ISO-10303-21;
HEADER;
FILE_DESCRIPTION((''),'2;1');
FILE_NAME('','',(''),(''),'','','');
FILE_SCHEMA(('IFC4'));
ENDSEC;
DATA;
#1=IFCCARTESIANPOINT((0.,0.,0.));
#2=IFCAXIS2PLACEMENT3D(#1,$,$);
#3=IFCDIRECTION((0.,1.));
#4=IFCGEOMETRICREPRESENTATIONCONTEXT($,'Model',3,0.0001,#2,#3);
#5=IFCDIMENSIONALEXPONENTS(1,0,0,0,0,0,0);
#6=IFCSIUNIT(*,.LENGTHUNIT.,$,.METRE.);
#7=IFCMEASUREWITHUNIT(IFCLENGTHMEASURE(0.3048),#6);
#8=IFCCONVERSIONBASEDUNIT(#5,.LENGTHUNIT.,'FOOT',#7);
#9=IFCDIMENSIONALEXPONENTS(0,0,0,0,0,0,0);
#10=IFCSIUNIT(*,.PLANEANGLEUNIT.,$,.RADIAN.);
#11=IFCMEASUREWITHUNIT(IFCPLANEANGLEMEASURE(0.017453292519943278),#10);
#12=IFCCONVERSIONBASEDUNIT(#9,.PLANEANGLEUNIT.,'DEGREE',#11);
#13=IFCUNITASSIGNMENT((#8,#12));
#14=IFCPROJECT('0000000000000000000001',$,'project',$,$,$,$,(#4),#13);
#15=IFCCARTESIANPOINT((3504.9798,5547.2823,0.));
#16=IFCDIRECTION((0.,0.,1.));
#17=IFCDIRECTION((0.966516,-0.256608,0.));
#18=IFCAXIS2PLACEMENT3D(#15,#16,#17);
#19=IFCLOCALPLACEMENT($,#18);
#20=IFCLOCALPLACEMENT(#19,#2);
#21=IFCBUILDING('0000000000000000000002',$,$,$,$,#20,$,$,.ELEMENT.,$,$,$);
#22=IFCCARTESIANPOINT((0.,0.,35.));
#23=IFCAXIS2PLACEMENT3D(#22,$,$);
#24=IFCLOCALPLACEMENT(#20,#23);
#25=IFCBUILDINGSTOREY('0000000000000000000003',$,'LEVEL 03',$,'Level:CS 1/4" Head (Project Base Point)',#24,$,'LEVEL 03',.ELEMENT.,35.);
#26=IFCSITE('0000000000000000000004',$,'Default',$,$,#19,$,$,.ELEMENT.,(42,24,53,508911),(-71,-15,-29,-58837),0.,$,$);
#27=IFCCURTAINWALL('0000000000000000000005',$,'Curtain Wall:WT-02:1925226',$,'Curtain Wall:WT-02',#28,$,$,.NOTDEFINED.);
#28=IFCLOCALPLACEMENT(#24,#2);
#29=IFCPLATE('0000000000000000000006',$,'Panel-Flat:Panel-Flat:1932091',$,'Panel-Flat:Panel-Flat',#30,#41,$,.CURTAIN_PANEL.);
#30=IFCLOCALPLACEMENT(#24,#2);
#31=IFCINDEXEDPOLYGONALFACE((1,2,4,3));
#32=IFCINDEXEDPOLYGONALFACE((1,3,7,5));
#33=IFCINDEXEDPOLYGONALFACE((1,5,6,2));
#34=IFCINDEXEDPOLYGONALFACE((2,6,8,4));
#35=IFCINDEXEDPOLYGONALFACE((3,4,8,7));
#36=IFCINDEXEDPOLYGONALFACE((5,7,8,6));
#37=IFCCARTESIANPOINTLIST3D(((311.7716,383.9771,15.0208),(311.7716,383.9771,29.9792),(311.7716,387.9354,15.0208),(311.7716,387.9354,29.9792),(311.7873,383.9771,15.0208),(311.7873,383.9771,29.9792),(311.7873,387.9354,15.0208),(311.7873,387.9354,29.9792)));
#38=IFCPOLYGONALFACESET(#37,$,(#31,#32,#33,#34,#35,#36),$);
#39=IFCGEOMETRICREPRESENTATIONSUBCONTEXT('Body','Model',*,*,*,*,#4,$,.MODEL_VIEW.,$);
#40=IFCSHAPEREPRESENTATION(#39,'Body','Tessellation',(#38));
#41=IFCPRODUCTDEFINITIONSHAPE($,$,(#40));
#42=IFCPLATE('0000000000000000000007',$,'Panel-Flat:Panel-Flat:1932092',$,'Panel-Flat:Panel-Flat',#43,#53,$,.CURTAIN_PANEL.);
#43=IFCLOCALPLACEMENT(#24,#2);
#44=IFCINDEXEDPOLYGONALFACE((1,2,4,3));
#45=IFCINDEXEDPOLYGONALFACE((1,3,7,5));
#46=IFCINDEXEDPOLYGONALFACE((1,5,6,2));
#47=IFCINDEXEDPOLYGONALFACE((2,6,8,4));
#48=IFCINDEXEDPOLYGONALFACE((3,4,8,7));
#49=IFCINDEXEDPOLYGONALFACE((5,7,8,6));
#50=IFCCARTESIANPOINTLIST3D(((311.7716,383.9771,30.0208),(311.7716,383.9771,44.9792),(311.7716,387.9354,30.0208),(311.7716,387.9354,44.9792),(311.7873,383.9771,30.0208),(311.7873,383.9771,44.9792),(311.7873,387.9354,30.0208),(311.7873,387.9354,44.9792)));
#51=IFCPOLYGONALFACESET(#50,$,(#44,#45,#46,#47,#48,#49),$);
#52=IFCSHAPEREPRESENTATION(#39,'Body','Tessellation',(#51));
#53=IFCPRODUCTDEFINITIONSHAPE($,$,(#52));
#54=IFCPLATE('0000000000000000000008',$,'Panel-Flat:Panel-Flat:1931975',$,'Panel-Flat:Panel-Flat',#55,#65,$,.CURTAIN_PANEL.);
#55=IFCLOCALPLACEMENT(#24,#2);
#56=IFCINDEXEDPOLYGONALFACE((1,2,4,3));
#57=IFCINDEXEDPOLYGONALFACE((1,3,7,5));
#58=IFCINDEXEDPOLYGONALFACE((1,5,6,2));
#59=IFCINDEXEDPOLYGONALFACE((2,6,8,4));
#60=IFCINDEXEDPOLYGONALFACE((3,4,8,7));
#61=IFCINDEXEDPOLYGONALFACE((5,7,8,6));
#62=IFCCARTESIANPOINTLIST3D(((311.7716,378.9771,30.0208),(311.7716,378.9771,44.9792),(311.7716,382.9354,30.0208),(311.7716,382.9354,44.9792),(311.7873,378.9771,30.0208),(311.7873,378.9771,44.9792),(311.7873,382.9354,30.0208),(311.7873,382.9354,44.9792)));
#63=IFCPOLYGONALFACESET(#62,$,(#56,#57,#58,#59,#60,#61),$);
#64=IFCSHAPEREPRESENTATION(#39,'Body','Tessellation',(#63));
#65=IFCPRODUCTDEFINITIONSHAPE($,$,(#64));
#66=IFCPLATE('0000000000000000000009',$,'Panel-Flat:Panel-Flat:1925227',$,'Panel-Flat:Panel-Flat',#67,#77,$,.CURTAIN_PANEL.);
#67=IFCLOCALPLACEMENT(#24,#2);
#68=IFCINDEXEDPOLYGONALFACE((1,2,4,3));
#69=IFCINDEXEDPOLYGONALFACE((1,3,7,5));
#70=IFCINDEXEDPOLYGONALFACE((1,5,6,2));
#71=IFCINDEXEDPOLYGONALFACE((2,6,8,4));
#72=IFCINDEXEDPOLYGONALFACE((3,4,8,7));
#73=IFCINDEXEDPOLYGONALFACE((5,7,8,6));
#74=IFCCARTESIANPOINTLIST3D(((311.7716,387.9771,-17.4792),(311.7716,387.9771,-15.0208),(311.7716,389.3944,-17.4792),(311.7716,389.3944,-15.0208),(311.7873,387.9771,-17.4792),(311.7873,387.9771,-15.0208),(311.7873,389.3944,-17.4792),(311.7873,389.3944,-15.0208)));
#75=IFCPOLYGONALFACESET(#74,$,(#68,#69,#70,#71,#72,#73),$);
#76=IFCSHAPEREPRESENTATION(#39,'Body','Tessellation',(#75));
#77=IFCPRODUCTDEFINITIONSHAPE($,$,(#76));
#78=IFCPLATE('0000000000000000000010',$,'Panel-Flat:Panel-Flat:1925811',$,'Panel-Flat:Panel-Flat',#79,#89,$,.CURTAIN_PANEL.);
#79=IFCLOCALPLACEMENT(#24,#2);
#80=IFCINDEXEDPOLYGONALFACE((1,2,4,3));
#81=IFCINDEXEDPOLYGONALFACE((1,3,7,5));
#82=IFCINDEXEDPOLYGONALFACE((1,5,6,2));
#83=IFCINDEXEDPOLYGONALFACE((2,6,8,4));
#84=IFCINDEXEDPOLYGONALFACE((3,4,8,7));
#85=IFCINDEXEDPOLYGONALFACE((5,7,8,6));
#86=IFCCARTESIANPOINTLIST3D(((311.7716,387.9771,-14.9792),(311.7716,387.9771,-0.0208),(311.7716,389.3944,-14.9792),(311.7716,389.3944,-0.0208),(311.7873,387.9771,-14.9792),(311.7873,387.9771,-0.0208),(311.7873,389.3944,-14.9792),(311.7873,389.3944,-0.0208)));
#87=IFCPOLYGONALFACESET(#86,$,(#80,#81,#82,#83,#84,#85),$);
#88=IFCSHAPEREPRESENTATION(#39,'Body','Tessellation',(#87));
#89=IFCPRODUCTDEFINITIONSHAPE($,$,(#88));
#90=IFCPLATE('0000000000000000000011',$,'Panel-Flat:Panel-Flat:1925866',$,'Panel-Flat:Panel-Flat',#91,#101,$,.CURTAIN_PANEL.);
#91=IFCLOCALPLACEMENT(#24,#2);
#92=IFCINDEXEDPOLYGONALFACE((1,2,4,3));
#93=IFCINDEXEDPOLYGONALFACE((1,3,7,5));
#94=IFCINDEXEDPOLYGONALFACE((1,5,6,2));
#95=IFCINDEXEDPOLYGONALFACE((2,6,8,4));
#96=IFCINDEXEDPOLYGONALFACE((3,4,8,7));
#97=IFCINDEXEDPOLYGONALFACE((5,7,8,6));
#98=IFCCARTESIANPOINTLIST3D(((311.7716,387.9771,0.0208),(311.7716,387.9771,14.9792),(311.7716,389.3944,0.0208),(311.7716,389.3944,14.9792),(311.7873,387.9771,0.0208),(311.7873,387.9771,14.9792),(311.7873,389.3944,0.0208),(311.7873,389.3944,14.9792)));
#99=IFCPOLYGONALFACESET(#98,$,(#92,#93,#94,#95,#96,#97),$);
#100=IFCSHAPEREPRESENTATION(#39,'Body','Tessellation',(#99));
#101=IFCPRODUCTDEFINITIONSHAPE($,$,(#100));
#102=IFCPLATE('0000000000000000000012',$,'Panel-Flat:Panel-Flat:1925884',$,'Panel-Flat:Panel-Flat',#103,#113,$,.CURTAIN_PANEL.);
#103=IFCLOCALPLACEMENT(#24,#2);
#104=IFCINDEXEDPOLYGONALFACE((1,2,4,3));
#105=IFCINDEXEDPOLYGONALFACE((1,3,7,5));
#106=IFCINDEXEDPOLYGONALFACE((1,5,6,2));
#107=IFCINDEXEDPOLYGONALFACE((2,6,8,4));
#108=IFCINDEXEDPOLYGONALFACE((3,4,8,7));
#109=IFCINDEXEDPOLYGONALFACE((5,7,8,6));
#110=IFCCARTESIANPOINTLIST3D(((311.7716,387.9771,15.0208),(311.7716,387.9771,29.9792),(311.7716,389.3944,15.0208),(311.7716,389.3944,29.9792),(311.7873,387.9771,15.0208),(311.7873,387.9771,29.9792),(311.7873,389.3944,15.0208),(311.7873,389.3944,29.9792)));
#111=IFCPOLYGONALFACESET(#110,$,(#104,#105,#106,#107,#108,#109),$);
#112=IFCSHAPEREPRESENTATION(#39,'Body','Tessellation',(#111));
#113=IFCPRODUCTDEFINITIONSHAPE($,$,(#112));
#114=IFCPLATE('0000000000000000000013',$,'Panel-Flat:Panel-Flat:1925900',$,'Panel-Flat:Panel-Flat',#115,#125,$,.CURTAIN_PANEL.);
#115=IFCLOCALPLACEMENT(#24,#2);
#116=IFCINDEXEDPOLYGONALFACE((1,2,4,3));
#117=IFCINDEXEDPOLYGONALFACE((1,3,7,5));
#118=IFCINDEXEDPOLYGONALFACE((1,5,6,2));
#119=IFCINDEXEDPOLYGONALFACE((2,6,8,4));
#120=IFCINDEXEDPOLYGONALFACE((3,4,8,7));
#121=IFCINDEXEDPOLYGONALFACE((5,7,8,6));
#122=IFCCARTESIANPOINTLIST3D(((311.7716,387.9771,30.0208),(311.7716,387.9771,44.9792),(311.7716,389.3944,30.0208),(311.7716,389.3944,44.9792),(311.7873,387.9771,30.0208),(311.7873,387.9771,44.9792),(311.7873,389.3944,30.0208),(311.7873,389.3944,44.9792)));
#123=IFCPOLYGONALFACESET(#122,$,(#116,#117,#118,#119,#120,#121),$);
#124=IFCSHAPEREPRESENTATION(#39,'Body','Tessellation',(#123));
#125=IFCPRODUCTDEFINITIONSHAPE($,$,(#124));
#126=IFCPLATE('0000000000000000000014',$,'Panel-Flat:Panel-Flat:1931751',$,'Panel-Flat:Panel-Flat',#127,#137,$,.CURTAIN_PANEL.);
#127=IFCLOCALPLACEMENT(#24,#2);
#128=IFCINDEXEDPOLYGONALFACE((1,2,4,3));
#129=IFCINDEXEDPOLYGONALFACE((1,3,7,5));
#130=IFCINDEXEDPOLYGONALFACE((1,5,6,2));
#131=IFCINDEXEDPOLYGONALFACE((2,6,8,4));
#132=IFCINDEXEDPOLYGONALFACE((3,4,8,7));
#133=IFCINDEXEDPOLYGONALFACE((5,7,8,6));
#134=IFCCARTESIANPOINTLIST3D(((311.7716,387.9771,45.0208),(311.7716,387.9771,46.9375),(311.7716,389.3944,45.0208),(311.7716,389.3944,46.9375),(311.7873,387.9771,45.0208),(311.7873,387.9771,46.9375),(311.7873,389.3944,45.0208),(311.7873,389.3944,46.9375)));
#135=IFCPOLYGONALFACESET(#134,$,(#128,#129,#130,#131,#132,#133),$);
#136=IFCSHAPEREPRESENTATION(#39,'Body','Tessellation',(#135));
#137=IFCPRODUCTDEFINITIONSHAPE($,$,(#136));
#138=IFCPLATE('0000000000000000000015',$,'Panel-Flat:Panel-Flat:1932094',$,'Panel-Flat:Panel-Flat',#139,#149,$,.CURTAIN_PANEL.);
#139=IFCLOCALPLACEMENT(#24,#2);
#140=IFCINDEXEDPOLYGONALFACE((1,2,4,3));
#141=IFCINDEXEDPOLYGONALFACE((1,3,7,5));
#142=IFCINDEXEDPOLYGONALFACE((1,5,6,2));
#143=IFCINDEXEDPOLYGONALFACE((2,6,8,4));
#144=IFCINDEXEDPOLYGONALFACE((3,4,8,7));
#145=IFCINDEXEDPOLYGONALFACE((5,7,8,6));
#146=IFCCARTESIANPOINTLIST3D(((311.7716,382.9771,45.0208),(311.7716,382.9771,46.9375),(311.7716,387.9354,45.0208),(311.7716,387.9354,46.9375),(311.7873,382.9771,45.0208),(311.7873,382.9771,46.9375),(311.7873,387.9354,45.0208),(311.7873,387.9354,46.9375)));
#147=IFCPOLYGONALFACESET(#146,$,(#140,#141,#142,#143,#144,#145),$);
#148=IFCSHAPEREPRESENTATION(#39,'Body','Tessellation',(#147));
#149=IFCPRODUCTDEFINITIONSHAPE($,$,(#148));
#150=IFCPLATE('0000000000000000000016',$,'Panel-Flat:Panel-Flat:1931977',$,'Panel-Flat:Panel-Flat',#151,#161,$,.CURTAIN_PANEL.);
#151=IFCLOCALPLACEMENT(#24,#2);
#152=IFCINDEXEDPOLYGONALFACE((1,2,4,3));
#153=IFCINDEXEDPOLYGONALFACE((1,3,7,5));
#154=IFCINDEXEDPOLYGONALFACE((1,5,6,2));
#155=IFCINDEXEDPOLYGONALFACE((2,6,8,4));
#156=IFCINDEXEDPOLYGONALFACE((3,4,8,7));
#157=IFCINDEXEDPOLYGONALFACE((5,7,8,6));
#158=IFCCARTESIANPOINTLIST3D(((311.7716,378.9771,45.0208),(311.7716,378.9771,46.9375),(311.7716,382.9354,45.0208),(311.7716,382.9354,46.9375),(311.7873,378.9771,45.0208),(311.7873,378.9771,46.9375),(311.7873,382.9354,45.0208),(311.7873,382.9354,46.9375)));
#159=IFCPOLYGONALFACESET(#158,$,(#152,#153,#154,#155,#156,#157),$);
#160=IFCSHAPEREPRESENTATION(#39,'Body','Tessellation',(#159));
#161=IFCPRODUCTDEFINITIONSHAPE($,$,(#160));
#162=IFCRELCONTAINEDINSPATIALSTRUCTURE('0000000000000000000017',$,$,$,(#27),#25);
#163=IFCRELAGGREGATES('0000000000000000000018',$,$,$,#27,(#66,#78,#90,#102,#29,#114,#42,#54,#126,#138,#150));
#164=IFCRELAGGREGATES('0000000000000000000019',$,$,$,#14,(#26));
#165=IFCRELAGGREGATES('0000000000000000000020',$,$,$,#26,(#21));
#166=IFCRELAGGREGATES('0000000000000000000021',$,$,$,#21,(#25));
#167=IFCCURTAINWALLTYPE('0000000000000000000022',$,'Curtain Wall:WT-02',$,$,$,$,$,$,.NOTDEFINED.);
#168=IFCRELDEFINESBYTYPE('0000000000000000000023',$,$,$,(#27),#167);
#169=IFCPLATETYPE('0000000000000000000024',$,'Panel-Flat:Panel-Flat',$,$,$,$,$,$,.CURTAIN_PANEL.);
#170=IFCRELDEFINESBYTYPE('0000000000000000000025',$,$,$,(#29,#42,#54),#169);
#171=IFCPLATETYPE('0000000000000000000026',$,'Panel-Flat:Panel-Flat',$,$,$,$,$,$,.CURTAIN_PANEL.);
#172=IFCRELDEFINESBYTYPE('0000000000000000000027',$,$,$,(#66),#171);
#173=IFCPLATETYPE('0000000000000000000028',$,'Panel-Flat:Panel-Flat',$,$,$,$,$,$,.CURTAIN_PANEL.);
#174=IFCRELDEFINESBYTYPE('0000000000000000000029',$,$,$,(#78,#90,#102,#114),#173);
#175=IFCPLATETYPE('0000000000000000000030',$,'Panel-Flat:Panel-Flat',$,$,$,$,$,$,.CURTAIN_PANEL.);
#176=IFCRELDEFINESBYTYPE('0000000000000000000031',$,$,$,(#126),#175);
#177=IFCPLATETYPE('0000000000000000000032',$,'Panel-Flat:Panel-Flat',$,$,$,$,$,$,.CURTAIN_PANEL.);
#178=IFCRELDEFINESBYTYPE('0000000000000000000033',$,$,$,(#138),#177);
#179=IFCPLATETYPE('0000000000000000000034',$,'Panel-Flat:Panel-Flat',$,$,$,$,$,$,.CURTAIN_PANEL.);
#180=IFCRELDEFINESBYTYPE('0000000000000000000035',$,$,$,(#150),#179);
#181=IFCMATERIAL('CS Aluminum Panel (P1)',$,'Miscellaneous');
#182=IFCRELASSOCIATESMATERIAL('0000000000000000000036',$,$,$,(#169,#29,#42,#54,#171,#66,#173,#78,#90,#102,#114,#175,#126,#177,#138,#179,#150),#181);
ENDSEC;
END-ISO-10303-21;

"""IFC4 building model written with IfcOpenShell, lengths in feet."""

from ifc_helpers import new_model, entity, si_unit, converted_unit, direction, frame, origin, place, context, subcontext, project, spatial, indexed_curve, outline, extrude, source, transform, mapped, material, type_object, type_shapes, element, aggregate, save


model = new_model("IFC4")

# Units and contexts
model_context = context("Model", 3, precision=0.0001, world=origin(), true_north=direction((0.0, 1.0)))
body_context = subcontext(model_context, "Body", "Model", "MODEL_VIEW")
ifc_project = project(units=[converted_unit("LENGTHUNIT", "FOOT", entity("IfcLengthMeasure", 0.3048), si_unit("LENGTHUNIT", "METRE"), dimensions=[1, 0, 0, 0, 0, 0, 0]), converted_unit("PLANEANGLEUNIT", "DEGREE", entity("IfcPlaneAngleMeasure", 0.017453292519943278), si_unit("PLANEANGLEUNIT", "RADIAN"), dimensions=[0, 0, 0, 0, 0, 0, 0])], contexts=[model_context])

# Site, building, storey
site_placement = place(None, frame((3504.9798, 5547.2823, 0.0), z_axis=(0.0, 0.0, 1.0), x_axis=(0.966516, -0.256608, 0.0)))
site = spatial("IfcSite", under=ifc_project, at=site_placement, Name="Default", CompositionType="ELEMENT", RefLatitude=(42, 24, 53, 508911), RefLongitude=(-71, -15, -29, -58837), RefElevation=0.0)
building_placement = place(site_placement, origin())
building = spatial("IfcBuilding", under=site, at=building_placement, CompositionType="ELEMENT")
storey_placement = place(building_placement, frame((0.0, 0.0, 35.0)))
storey = spatial("IfcBuildingStorey", under=building, at=storey_placement, Name="LEVEL 03", ObjectType="Level:CS 1/4\" Head (Project Base Point)", LongName="LEVEL 03", CompositionType="ELEMENT", Elevation=35.0)

# Curtain wall, plates
curtain_wall_type = type_object("IfcCurtainWallType", Name="Curtain Wall:WT-02", PredefinedType="NOTDEFINED")
curtain_wall_1_placement = place(storey_placement, frame((0.0, 0.0, -35.0)))
curtain_wall_1 = element("IfcCurtainWall", 1, at=curtain_wall_1_placement, inside=storey, type_object=curtain_wall_type, Name="Curtain Wall:WT-02:1925226", ObjectType="Curtain Wall:WT-02", PredefinedType="NOTDEFINED")
ifc_material_1 = material(Name="CS Aluminum Panel (P1)", Category="Miscellaneous")
plate_type_1 = type_object("IfcPlateType", Name="Panel-Flat:Panel-Flat", PredefinedType="CURTAIN_PANEL", material=ifc_material_1)
shared_shape_1 = source(origin(), body_context, "Body", "SweptSolid", [
    extrude(outline(indexed_curve([(-0.0078, -1.9792), (0.0078, -1.9792), (0.0078, 1.9792), (-0.0078, 1.9792), (-0.0078, -1.9792)], self_intersect=False)), frame((1.9792, 0.0078, 0.0), z_axis=(0.0, 0.0, 1.0), x_axis=(0.0, -1.0, 0.0)), (0.0, 0.0, 1.0), 14.9583),
])
type_shapes(plate_type_1, [shared_shape_1])
plate_1_placement = place(curtain_wall_1_placement, frame((311.7716, 387.9354, 50.0208), z_axis=(0.0, 0.0, 1.0), x_axis=(0.0, -1.0, 0.0)))
plate_1 = element("IfcPlate", 2, at=plate_1_placement, type_object=plate_type_1, material=ifc_material_1, Name="Panel-Flat:Panel-Flat:1932091", ObjectType="Panel-Flat:Panel-Flat", PredefinedType="CURTAIN_PANEL", context=body_context, shape_type="MappedRepresentation", body=[
    mapped(shared_shape_1, transform((0.0, 0.0, 0.0), scale=1.0)),
])
plate_2_placement = place(curtain_wall_1_placement, frame((311.7716, 387.9354, 65.0208), z_axis=(0.0, 0.0, 1.0), x_axis=(0.0, -1.0, 0.0)))
plate_2 = element("IfcPlate", 3, at=plate_2_placement, type_object=plate_type_1, material=ifc_material_1, Name="Panel-Flat:Panel-Flat:1932092", ObjectType="Panel-Flat:Panel-Flat", PredefinedType="CURTAIN_PANEL", context=body_context, shape_type="MappedRepresentation", body=[
    mapped(shared_shape_1, transform((0.0, 0.0, 0.0), scale=1.0)),
])
plate_3_placement = place(curtain_wall_1_placement, frame((311.7716, 382.9354, 65.0208), z_axis=(0.0, 0.0, 1.0), x_axis=(0.0, -1.0, 0.0)))
plate_3 = element("IfcPlate", 4, at=plate_3_placement, type_object=plate_type_1, material=ifc_material_1, Name="Panel-Flat:Panel-Flat:1931975", ObjectType="Panel-Flat:Panel-Flat", PredefinedType="CURTAIN_PANEL", context=body_context, shape_type="MappedRepresentation", body=[
    mapped(shared_shape_1, transform((0.0, 0.0, 0.0), scale=1.0)),
])
plate_type_2 = type_object("IfcPlateType", Name="Panel-Flat:Panel-Flat", PredefinedType="CURTAIN_PANEL", material=ifc_material_1)
shared_shape_2 = source(origin(), body_context, "Body", "SweptSolid", [
    extrude(outline(indexed_curve([(-0.0078, -0.7087), (0.0078, -0.7087), (0.0078, 0.7087), (-0.0078, 0.7087), (-0.0078, -0.7087)], self_intersect=False)), frame((0.7087, 0.0078, 0.0), z_axis=(0.0, 0.0, 1.0), x_axis=(0.0, -1.0, 0.0)), (0.0, 0.0, 1.0), 2.4583),
])
type_shapes(plate_type_2, [shared_shape_2])
plate_4_placement = place(curtain_wall_1_placement, frame((311.7716, 389.3944, 17.5208), z_axis=(0.0, 0.0, 1.0), x_axis=(0.0, -1.0, 0.0)))
plate_4 = element("IfcPlate", 5, at=plate_4_placement, type_object=plate_type_2, material=ifc_material_1, Name="Panel-Flat:Panel-Flat:1925227", ObjectType="Panel-Flat:Panel-Flat", PredefinedType="CURTAIN_PANEL", context=body_context, shape_type="MappedRepresentation", body=[
    mapped(shared_shape_2, transform((0.0, 0.0, 0.0), scale=1.0)),
])
plate_type_3 = type_object("IfcPlateType", Name="Panel-Flat:Panel-Flat", PredefinedType="CURTAIN_PANEL", material=ifc_material_1)
shared_shape_3 = source(origin(), body_context, "Body", "SweptSolid", [
    extrude(outline(indexed_curve([(-0.0078, -0.7087), (0.0078, -0.7087), (0.0078, 0.7087), (-0.0078, 0.7087), (-0.0078, -0.7087)], self_intersect=False)), frame((0.7087, 0.0078, 0.0), z_axis=(0.0, 0.0, 1.0), x_axis=(0.0, -1.0, 0.0)), (0.0, 0.0, 1.0), 14.9583),
])
type_shapes(plate_type_3, [shared_shape_3])
plate_5_placement = place(curtain_wall_1_placement, frame((311.7716, 389.3944, 20.0208), z_axis=(0.0, 0.0, 1.0), x_axis=(0.0, -1.0, 0.0)))
plate_5 = element("IfcPlate", 6, at=plate_5_placement, type_object=plate_type_3, material=ifc_material_1, Name="Panel-Flat:Panel-Flat:1925811", ObjectType="Panel-Flat:Panel-Flat", PredefinedType="CURTAIN_PANEL", context=body_context, shape_type="MappedRepresentation", body=[
    mapped(shared_shape_3, transform((0.0, 0.0, 0.0), scale=1.0)),
])
plate_6_placement = place(curtain_wall_1_placement, frame((311.7716, 389.3944, 35.0208), z_axis=(0.0, 0.0, 1.0), x_axis=(0.0, -1.0, 0.0)))
plate_6 = element("IfcPlate", 7, at=plate_6_placement, type_object=plate_type_3, material=ifc_material_1, Name="Panel-Flat:Panel-Flat:1925866", ObjectType="Panel-Flat:Panel-Flat", PredefinedType="CURTAIN_PANEL", context=body_context, shape_type="MappedRepresentation", body=[
    mapped(shared_shape_3, transform((0.0, 0.0, 0.0), scale=1.0)),
])
plate_7_placement = place(curtain_wall_1_placement, frame((311.7716, 389.3944, 50.0208), z_axis=(0.0, 0.0, 1.0), x_axis=(0.0, -1.0, 0.0)))
plate_7 = element("IfcPlate", 8, at=plate_7_placement, type_object=plate_type_3, material=ifc_material_1, Name="Panel-Flat:Panel-Flat:1925884", ObjectType="Panel-Flat:Panel-Flat", PredefinedType="CURTAIN_PANEL", context=body_context, shape_type="MappedRepresentation", body=[
    mapped(shared_shape_3, transform((0.0, 0.0, 0.0), scale=1.0)),
])
plate_8_placement = place(curtain_wall_1_placement, frame((311.7716, 389.3944, 65.0208), z_axis=(0.0, 0.0, 1.0), x_axis=(0.0, -1.0, 0.0)))
plate_8 = element("IfcPlate", 9, at=plate_8_placement, type_object=plate_type_3, material=ifc_material_1, Name="Panel-Flat:Panel-Flat:1925900", ObjectType="Panel-Flat:Panel-Flat", PredefinedType="CURTAIN_PANEL", context=body_context, shape_type="MappedRepresentation", body=[
    mapped(shared_shape_3, transform((0.0, 0.0, 0.0), scale=1.0)),
])
plate_type_4 = type_object("IfcPlateType", Name="Panel-Flat:Panel-Flat", PredefinedType="CURTAIN_PANEL", material=ifc_material_1)
shared_shape_4 = source(origin(), body_context, "Body", "SweptSolid", [
    extrude(outline(indexed_curve([(-0.0078, -0.7087), (0.0078, -0.7087), (0.0078, 0.7087), (-0.0078, 0.7087), (-0.0078, -0.7087)], self_intersect=False)), frame((0.7087, 0.0078, 0.0), z_axis=(0.0, 0.0, 1.0), x_axis=(0.0, -1.0, 0.0)), (0.0, 0.0, 1.0), 1.9167),
])
type_shapes(plate_type_4, [shared_shape_4])
plate_9_placement = place(curtain_wall_1_placement, frame((311.7716, 389.3944, 80.0208), z_axis=(0.0, 0.0, 1.0), x_axis=(0.0, -1.0, 0.0)))
plate_9 = element("IfcPlate", 10, at=plate_9_placement, type_object=plate_type_4, material=ifc_material_1, Name="Panel-Flat:Panel-Flat:1931751", ObjectType="Panel-Flat:Panel-Flat", PredefinedType="CURTAIN_PANEL", context=body_context, shape_type="MappedRepresentation", body=[
    mapped(shared_shape_4, transform((0.0, 0.0, 0.0), scale=1.0)),
])
plate_type_5 = type_object("IfcPlateType", Name="Panel-Flat:Panel-Flat", PredefinedType="CURTAIN_PANEL", material=ifc_material_1)
shared_shape_5 = source(origin(), body_context, "Body", "SweptSolid", [
    extrude(outline(indexed_curve([(-0.0078, -2.4792), (0.0078, -2.4792), (0.0078, 2.4792), (-0.0078, 2.4792), (-0.0078, -2.4792)], self_intersect=False)), frame((2.4792, 0.0078, 0.0), z_axis=(0.0, 0.0, 1.0), x_axis=(0.0, -1.0, 0.0)), (0.0, 0.0, 1.0), 1.9167),
])
type_shapes(plate_type_5, [shared_shape_5])
plate_10_placement = place(curtain_wall_1_placement, frame((311.7716, 387.9354, 80.0208), z_axis=(0.0, 0.0, 1.0), x_axis=(0.0, -1.0, 0.0)))
plate_10 = element("IfcPlate", 11, at=plate_10_placement, type_object=plate_type_5, material=ifc_material_1, Name="Panel-Flat:Panel-Flat:1932094", ObjectType="Panel-Flat:Panel-Flat", PredefinedType="CURTAIN_PANEL", context=body_context, shape_type="MappedRepresentation", body=[
    mapped(shared_shape_5, transform((0.0, 0.0, 0.0), scale=1.0)),
])
plate_type_6 = type_object("IfcPlateType", Name="Panel-Flat:Panel-Flat", PredefinedType="CURTAIN_PANEL", material=ifc_material_1)
shared_shape_6 = source(origin(), body_context, "Body", "SweptSolid", [
    extrude(outline(indexed_curve([(-0.0078, -1.9792), (0.0078, -1.9792), (0.0078, 1.9792), (-0.0078, 1.9792), (-0.0078, -1.9792)], self_intersect=False)), frame((1.9792, 0.0078, 0.0), z_axis=(0.0, 0.0, 1.0), x_axis=(0.0, -1.0, 0.0)), (0.0, 0.0, 1.0), 1.9167),
])
type_shapes(plate_type_6, [shared_shape_6])
plate_11_placement = place(curtain_wall_1_placement, frame((311.7716, 382.9354, 80.0208), z_axis=(0.0, 0.0, 1.0), x_axis=(0.0, -1.0, 0.0)))
plate_11 = element("IfcPlate", 12, at=plate_11_placement, type_object=plate_type_6, material=ifc_material_1, Name="Panel-Flat:Panel-Flat:1931977", ObjectType="Panel-Flat:Panel-Flat", PredefinedType="CURTAIN_PANEL", context=body_context, shape_type="MappedRepresentation", body=[
    mapped(shared_shape_6, transform((0.0, 0.0, 0.0), scale=1.0)),
])
aggregate(curtain_wall_1, [plate_4, plate_5, plate_6, plate_7, plate_1, plate_8, plate_2, plate_3, plate_9, plate_10, plate_11])

save(model, "model.ifc")
